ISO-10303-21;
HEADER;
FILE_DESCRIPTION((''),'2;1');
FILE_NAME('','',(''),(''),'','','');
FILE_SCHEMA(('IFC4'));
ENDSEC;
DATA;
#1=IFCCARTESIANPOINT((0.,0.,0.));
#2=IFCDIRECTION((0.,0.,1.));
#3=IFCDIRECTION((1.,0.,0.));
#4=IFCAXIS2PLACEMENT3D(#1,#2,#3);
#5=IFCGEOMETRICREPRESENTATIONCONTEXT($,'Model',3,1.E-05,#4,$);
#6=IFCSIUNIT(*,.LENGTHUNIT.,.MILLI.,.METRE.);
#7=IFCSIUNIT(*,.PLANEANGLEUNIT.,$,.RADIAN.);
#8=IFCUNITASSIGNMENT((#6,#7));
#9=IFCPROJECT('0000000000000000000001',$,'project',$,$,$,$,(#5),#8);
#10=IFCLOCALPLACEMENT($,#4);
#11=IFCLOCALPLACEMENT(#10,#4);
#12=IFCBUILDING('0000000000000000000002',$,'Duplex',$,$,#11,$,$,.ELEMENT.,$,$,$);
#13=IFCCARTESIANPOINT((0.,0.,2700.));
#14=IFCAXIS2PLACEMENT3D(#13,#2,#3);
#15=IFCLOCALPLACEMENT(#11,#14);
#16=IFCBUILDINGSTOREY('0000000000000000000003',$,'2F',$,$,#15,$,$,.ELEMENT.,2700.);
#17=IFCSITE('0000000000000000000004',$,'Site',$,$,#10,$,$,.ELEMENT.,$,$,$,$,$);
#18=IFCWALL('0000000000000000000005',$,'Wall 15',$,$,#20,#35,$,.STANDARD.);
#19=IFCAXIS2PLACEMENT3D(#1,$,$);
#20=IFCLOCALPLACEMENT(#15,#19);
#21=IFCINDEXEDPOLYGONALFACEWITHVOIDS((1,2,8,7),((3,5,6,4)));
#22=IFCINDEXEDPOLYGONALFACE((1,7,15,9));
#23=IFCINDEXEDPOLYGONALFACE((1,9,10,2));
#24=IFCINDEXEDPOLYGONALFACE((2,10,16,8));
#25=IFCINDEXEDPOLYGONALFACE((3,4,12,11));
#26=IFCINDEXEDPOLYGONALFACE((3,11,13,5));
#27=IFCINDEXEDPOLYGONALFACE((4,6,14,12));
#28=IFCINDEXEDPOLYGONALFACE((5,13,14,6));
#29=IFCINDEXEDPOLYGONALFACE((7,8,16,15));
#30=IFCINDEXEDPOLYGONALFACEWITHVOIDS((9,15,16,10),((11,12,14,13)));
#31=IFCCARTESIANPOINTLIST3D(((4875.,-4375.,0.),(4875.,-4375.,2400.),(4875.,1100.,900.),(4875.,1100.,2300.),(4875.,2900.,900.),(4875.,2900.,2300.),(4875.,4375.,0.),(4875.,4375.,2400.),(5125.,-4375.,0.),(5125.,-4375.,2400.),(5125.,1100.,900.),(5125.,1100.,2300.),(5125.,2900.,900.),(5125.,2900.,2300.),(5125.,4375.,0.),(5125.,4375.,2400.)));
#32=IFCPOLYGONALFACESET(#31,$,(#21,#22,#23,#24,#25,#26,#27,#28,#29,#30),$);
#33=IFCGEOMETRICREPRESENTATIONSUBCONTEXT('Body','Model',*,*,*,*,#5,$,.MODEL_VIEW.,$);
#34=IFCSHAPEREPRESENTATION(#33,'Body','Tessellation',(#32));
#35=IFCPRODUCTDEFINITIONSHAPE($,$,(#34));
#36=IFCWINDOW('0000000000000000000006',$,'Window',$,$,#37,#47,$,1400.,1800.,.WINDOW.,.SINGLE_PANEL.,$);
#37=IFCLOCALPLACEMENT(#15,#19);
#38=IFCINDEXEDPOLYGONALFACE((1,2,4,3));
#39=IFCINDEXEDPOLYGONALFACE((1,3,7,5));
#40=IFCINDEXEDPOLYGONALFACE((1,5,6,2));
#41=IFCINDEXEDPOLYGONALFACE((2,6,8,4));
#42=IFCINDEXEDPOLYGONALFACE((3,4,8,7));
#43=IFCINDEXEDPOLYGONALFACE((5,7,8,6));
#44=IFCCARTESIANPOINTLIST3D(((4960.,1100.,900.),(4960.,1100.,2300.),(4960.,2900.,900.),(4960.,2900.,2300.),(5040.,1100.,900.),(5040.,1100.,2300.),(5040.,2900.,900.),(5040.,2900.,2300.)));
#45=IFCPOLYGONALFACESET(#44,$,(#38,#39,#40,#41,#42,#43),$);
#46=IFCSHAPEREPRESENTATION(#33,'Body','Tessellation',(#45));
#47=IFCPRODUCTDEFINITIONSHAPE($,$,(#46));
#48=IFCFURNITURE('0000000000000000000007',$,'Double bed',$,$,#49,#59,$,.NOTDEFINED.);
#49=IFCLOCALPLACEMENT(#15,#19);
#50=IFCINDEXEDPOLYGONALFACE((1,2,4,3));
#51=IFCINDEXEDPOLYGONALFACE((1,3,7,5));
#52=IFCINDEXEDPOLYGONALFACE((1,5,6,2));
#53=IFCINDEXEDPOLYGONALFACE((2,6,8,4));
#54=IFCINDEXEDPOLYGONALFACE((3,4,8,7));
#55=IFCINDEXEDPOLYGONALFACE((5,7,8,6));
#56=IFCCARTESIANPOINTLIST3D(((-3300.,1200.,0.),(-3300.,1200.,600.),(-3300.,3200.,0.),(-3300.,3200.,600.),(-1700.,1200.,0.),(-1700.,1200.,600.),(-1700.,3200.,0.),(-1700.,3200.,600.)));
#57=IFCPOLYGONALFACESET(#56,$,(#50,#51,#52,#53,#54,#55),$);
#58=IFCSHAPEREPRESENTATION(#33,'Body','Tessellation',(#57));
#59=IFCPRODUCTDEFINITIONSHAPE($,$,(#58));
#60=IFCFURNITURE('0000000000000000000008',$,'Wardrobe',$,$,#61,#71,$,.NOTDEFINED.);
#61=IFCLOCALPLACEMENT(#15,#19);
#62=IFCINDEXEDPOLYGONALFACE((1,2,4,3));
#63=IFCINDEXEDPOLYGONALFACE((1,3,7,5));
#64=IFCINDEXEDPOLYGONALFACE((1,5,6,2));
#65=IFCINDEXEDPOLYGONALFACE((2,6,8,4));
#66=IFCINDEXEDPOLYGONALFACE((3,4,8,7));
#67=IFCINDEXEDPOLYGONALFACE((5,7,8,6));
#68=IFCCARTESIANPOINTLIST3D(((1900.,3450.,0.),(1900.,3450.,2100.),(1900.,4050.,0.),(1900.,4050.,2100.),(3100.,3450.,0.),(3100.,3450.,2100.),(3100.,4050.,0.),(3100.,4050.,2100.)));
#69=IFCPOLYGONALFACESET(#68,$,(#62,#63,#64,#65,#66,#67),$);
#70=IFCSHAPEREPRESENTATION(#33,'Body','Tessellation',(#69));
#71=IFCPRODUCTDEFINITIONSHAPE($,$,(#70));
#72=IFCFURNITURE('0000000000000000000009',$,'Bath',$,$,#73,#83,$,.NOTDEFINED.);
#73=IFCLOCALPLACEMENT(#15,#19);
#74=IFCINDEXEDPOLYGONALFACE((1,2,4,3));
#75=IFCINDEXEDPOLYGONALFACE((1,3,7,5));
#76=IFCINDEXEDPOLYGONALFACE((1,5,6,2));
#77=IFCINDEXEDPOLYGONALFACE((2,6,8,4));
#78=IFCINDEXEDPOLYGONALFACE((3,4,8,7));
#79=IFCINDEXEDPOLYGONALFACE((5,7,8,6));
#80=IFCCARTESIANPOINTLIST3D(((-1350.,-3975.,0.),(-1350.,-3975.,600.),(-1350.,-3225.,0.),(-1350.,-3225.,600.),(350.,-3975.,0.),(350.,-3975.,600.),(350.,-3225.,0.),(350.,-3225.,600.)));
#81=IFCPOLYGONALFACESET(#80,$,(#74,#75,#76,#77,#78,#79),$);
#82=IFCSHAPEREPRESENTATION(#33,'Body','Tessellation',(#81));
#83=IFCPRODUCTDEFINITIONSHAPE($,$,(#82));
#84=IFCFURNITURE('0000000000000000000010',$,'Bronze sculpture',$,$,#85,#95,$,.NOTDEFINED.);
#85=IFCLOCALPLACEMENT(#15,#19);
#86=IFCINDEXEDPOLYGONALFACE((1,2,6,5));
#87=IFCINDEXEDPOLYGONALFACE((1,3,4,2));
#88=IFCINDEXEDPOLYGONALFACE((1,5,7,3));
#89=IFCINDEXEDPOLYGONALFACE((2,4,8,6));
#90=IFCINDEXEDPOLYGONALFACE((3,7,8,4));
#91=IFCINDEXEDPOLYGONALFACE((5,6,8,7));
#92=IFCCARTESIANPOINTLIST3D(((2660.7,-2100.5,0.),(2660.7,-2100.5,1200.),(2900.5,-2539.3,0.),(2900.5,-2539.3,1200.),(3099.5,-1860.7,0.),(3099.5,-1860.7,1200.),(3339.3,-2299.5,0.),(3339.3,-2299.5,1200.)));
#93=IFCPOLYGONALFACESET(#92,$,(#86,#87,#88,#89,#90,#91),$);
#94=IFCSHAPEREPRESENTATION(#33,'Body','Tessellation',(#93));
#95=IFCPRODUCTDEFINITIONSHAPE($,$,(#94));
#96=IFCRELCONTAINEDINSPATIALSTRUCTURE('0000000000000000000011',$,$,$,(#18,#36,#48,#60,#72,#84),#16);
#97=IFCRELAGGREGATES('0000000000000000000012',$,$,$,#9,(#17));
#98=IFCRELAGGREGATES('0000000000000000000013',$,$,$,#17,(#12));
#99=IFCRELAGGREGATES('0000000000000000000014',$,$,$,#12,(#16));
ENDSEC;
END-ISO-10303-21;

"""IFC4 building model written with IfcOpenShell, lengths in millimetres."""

from ifc_helpers import new_model, si_unit, frame, frame_2d, origin, origin_with_axes, origin_2d, place, context, subcontext, project, spatial, rectangle, extrude, element, fill, save


model = new_model("IFC4")

# Units and contexts
model_context = context("Model", 3, precision=1e-05, world=origin_with_axes())
body_context = subcontext(model_context, "Body", "Model", "MODEL_VIEW")
ifc_project = project(units=[si_unit("LENGTHUNIT", "METRE", prefix="MILLI"), si_unit("PLANEANGLEUNIT", "RADIAN")], contexts=[model_context])

# Site, building, storey
site_placement = place(None, origin_with_axes())
site = spatial("IfcSite", under=ifc_project, at=site_placement, Name="Site", CompositionType="ELEMENT")
building_placement = place(site_placement, origin_with_axes())
building = spatial("IfcBuilding", under=site, at=building_placement, Name="Duplex", CompositionType="ELEMENT")
storey_placement = place(building_placement, frame((0.0, 0.0, 2700.0), z_axis=(0.0, 0.0, 1.0), x_axis=(1.0, 0.0, 0.0)))
storey = spatial("IfcBuildingStorey", under=building, at=storey_placement, Name="2F", CompositionType="ELEMENT", Elevation=2700.0)

# Wall, opening, window
wall_1_placement = place(storey_placement, frame((5000.0, 4250.0, 0.0), z_axis=(0.0, 0.0, 1.0), x_axis=(0.0, -1.0, 0.0)))
wall_1 = element("IfcWall", 1, at=wall_1_placement, inside=storey, Name="Wall 15", PredefinedType="STANDARD", context=body_context, shape_type="SweptSolid", body=[
    extrude(rectangle(XDim=8750.0, YDim=250.0, at=frame_2d((4250.0, 0.0))), origin(), (0.0, 0.0, 1.0), 2400.0),
])
opening_1_placement = place(wall_1_placement, frame((1350.0, 0.0, 900.0), z_axis=(0.0, 0.0, 1.0), x_axis=(1.0, 0.0, 0.0)))
opening_1 = element("IfcOpeningElement", 2, at=opening_1_placement, cuts=wall_1, PredefinedType="OPENING", context=body_context, shape_type="SweptSolid", body=[
    extrude(rectangle(XDim=1800.0, YDim=350.0, at=frame_2d((900.0, 0.0))), origin(), (0.0, 0.0, 1.0), 1400.0),
])
window_1_placement = place(opening_1_placement, origin_with_axes())
window_1 = element("IfcWindow", 3, at=window_1_placement, inside=storey, Name="Window", OverallHeight=1400.0, OverallWidth=1800.0, PartitioningType="SINGLE_PANEL", PredefinedType="WINDOW", context=body_context, shape_type="SweptSolid", body=[
    extrude(rectangle(XDim=1800.0, YDim=80.0, at=frame_2d((900.0, 0.0))), origin(), (0.0, 0.0, 1.0), 1400.0),
])
fill(opening_1, window_1)

# Furniture
furniture_1_placement = place(storey_placement, frame((-2500.0, 2200.0, 0.0), z_axis=(0.0, 0.0, 1.0), x_axis=(1.0, 0.0, 0.0)))
element("IfcFurniture", 4, at=furniture_1_placement, inside=storey, Name="Double bed", PredefinedType="NOTDEFINED", context=body_context, shape_type="SweptSolid", body=[
    extrude(rectangle(XDim=1600.0, YDim=2000.0, at=origin_2d()), origin(), (0.0, 0.0, 1.0), 600.0),
])
furniture_2_placement = place(storey_placement, frame((2500.0, 3750.0, 0.0), z_axis=(0.0, 0.0, 1.0), x_axis=(1.0, 0.0, 0.0)))
element("IfcFurniture", 5, at=furniture_2_placement, inside=storey, Name="Wardrobe", PredefinedType="NOTDEFINED", context=body_context, shape_type="SweptSolid", body=[
    extrude(rectangle(XDim=1200.0, YDim=600.0, at=origin_2d()), origin(), (0.0, 0.0, 1.0), 2100.0),
])
furniture_3_placement = place(storey_placement, frame((-500.0, -3600.0, 0.0), z_axis=(0.0, 0.0, 1.0), x_axis=(1.0, 0.0, 0.0)))
element("IfcFurniture", 6, at=furniture_3_placement, inside=storey, Name="Bath", PredefinedType="NOTDEFINED", context=body_context, shape_type="SweptSolid", body=[
    extrude(rectangle(XDim=1700.0, YDim=750.0, at=origin_2d()), origin(), (0.0, 0.0, 1.0), 600.0),
])
furniture_4_placement = place(storey_placement, frame((3000.0, -2200.0, 0.0), z_axis=(0.0, 0.0, 1.0), x_axis=(0.877583, 0.479426, 0.0)))
element("IfcFurniture", 7, at=furniture_4_placement, inside=storey, Name="Bronze sculpture", PredefinedType="NOTDEFINED", context=body_context, shape_type="SweptSolid", body=[
    extrude(rectangle(XDim=500.0, YDim=500.0, at=origin_2d()), origin(), (0.0, 0.0, 1.0), 1200.0),
])

save(model, "model.ifc")
